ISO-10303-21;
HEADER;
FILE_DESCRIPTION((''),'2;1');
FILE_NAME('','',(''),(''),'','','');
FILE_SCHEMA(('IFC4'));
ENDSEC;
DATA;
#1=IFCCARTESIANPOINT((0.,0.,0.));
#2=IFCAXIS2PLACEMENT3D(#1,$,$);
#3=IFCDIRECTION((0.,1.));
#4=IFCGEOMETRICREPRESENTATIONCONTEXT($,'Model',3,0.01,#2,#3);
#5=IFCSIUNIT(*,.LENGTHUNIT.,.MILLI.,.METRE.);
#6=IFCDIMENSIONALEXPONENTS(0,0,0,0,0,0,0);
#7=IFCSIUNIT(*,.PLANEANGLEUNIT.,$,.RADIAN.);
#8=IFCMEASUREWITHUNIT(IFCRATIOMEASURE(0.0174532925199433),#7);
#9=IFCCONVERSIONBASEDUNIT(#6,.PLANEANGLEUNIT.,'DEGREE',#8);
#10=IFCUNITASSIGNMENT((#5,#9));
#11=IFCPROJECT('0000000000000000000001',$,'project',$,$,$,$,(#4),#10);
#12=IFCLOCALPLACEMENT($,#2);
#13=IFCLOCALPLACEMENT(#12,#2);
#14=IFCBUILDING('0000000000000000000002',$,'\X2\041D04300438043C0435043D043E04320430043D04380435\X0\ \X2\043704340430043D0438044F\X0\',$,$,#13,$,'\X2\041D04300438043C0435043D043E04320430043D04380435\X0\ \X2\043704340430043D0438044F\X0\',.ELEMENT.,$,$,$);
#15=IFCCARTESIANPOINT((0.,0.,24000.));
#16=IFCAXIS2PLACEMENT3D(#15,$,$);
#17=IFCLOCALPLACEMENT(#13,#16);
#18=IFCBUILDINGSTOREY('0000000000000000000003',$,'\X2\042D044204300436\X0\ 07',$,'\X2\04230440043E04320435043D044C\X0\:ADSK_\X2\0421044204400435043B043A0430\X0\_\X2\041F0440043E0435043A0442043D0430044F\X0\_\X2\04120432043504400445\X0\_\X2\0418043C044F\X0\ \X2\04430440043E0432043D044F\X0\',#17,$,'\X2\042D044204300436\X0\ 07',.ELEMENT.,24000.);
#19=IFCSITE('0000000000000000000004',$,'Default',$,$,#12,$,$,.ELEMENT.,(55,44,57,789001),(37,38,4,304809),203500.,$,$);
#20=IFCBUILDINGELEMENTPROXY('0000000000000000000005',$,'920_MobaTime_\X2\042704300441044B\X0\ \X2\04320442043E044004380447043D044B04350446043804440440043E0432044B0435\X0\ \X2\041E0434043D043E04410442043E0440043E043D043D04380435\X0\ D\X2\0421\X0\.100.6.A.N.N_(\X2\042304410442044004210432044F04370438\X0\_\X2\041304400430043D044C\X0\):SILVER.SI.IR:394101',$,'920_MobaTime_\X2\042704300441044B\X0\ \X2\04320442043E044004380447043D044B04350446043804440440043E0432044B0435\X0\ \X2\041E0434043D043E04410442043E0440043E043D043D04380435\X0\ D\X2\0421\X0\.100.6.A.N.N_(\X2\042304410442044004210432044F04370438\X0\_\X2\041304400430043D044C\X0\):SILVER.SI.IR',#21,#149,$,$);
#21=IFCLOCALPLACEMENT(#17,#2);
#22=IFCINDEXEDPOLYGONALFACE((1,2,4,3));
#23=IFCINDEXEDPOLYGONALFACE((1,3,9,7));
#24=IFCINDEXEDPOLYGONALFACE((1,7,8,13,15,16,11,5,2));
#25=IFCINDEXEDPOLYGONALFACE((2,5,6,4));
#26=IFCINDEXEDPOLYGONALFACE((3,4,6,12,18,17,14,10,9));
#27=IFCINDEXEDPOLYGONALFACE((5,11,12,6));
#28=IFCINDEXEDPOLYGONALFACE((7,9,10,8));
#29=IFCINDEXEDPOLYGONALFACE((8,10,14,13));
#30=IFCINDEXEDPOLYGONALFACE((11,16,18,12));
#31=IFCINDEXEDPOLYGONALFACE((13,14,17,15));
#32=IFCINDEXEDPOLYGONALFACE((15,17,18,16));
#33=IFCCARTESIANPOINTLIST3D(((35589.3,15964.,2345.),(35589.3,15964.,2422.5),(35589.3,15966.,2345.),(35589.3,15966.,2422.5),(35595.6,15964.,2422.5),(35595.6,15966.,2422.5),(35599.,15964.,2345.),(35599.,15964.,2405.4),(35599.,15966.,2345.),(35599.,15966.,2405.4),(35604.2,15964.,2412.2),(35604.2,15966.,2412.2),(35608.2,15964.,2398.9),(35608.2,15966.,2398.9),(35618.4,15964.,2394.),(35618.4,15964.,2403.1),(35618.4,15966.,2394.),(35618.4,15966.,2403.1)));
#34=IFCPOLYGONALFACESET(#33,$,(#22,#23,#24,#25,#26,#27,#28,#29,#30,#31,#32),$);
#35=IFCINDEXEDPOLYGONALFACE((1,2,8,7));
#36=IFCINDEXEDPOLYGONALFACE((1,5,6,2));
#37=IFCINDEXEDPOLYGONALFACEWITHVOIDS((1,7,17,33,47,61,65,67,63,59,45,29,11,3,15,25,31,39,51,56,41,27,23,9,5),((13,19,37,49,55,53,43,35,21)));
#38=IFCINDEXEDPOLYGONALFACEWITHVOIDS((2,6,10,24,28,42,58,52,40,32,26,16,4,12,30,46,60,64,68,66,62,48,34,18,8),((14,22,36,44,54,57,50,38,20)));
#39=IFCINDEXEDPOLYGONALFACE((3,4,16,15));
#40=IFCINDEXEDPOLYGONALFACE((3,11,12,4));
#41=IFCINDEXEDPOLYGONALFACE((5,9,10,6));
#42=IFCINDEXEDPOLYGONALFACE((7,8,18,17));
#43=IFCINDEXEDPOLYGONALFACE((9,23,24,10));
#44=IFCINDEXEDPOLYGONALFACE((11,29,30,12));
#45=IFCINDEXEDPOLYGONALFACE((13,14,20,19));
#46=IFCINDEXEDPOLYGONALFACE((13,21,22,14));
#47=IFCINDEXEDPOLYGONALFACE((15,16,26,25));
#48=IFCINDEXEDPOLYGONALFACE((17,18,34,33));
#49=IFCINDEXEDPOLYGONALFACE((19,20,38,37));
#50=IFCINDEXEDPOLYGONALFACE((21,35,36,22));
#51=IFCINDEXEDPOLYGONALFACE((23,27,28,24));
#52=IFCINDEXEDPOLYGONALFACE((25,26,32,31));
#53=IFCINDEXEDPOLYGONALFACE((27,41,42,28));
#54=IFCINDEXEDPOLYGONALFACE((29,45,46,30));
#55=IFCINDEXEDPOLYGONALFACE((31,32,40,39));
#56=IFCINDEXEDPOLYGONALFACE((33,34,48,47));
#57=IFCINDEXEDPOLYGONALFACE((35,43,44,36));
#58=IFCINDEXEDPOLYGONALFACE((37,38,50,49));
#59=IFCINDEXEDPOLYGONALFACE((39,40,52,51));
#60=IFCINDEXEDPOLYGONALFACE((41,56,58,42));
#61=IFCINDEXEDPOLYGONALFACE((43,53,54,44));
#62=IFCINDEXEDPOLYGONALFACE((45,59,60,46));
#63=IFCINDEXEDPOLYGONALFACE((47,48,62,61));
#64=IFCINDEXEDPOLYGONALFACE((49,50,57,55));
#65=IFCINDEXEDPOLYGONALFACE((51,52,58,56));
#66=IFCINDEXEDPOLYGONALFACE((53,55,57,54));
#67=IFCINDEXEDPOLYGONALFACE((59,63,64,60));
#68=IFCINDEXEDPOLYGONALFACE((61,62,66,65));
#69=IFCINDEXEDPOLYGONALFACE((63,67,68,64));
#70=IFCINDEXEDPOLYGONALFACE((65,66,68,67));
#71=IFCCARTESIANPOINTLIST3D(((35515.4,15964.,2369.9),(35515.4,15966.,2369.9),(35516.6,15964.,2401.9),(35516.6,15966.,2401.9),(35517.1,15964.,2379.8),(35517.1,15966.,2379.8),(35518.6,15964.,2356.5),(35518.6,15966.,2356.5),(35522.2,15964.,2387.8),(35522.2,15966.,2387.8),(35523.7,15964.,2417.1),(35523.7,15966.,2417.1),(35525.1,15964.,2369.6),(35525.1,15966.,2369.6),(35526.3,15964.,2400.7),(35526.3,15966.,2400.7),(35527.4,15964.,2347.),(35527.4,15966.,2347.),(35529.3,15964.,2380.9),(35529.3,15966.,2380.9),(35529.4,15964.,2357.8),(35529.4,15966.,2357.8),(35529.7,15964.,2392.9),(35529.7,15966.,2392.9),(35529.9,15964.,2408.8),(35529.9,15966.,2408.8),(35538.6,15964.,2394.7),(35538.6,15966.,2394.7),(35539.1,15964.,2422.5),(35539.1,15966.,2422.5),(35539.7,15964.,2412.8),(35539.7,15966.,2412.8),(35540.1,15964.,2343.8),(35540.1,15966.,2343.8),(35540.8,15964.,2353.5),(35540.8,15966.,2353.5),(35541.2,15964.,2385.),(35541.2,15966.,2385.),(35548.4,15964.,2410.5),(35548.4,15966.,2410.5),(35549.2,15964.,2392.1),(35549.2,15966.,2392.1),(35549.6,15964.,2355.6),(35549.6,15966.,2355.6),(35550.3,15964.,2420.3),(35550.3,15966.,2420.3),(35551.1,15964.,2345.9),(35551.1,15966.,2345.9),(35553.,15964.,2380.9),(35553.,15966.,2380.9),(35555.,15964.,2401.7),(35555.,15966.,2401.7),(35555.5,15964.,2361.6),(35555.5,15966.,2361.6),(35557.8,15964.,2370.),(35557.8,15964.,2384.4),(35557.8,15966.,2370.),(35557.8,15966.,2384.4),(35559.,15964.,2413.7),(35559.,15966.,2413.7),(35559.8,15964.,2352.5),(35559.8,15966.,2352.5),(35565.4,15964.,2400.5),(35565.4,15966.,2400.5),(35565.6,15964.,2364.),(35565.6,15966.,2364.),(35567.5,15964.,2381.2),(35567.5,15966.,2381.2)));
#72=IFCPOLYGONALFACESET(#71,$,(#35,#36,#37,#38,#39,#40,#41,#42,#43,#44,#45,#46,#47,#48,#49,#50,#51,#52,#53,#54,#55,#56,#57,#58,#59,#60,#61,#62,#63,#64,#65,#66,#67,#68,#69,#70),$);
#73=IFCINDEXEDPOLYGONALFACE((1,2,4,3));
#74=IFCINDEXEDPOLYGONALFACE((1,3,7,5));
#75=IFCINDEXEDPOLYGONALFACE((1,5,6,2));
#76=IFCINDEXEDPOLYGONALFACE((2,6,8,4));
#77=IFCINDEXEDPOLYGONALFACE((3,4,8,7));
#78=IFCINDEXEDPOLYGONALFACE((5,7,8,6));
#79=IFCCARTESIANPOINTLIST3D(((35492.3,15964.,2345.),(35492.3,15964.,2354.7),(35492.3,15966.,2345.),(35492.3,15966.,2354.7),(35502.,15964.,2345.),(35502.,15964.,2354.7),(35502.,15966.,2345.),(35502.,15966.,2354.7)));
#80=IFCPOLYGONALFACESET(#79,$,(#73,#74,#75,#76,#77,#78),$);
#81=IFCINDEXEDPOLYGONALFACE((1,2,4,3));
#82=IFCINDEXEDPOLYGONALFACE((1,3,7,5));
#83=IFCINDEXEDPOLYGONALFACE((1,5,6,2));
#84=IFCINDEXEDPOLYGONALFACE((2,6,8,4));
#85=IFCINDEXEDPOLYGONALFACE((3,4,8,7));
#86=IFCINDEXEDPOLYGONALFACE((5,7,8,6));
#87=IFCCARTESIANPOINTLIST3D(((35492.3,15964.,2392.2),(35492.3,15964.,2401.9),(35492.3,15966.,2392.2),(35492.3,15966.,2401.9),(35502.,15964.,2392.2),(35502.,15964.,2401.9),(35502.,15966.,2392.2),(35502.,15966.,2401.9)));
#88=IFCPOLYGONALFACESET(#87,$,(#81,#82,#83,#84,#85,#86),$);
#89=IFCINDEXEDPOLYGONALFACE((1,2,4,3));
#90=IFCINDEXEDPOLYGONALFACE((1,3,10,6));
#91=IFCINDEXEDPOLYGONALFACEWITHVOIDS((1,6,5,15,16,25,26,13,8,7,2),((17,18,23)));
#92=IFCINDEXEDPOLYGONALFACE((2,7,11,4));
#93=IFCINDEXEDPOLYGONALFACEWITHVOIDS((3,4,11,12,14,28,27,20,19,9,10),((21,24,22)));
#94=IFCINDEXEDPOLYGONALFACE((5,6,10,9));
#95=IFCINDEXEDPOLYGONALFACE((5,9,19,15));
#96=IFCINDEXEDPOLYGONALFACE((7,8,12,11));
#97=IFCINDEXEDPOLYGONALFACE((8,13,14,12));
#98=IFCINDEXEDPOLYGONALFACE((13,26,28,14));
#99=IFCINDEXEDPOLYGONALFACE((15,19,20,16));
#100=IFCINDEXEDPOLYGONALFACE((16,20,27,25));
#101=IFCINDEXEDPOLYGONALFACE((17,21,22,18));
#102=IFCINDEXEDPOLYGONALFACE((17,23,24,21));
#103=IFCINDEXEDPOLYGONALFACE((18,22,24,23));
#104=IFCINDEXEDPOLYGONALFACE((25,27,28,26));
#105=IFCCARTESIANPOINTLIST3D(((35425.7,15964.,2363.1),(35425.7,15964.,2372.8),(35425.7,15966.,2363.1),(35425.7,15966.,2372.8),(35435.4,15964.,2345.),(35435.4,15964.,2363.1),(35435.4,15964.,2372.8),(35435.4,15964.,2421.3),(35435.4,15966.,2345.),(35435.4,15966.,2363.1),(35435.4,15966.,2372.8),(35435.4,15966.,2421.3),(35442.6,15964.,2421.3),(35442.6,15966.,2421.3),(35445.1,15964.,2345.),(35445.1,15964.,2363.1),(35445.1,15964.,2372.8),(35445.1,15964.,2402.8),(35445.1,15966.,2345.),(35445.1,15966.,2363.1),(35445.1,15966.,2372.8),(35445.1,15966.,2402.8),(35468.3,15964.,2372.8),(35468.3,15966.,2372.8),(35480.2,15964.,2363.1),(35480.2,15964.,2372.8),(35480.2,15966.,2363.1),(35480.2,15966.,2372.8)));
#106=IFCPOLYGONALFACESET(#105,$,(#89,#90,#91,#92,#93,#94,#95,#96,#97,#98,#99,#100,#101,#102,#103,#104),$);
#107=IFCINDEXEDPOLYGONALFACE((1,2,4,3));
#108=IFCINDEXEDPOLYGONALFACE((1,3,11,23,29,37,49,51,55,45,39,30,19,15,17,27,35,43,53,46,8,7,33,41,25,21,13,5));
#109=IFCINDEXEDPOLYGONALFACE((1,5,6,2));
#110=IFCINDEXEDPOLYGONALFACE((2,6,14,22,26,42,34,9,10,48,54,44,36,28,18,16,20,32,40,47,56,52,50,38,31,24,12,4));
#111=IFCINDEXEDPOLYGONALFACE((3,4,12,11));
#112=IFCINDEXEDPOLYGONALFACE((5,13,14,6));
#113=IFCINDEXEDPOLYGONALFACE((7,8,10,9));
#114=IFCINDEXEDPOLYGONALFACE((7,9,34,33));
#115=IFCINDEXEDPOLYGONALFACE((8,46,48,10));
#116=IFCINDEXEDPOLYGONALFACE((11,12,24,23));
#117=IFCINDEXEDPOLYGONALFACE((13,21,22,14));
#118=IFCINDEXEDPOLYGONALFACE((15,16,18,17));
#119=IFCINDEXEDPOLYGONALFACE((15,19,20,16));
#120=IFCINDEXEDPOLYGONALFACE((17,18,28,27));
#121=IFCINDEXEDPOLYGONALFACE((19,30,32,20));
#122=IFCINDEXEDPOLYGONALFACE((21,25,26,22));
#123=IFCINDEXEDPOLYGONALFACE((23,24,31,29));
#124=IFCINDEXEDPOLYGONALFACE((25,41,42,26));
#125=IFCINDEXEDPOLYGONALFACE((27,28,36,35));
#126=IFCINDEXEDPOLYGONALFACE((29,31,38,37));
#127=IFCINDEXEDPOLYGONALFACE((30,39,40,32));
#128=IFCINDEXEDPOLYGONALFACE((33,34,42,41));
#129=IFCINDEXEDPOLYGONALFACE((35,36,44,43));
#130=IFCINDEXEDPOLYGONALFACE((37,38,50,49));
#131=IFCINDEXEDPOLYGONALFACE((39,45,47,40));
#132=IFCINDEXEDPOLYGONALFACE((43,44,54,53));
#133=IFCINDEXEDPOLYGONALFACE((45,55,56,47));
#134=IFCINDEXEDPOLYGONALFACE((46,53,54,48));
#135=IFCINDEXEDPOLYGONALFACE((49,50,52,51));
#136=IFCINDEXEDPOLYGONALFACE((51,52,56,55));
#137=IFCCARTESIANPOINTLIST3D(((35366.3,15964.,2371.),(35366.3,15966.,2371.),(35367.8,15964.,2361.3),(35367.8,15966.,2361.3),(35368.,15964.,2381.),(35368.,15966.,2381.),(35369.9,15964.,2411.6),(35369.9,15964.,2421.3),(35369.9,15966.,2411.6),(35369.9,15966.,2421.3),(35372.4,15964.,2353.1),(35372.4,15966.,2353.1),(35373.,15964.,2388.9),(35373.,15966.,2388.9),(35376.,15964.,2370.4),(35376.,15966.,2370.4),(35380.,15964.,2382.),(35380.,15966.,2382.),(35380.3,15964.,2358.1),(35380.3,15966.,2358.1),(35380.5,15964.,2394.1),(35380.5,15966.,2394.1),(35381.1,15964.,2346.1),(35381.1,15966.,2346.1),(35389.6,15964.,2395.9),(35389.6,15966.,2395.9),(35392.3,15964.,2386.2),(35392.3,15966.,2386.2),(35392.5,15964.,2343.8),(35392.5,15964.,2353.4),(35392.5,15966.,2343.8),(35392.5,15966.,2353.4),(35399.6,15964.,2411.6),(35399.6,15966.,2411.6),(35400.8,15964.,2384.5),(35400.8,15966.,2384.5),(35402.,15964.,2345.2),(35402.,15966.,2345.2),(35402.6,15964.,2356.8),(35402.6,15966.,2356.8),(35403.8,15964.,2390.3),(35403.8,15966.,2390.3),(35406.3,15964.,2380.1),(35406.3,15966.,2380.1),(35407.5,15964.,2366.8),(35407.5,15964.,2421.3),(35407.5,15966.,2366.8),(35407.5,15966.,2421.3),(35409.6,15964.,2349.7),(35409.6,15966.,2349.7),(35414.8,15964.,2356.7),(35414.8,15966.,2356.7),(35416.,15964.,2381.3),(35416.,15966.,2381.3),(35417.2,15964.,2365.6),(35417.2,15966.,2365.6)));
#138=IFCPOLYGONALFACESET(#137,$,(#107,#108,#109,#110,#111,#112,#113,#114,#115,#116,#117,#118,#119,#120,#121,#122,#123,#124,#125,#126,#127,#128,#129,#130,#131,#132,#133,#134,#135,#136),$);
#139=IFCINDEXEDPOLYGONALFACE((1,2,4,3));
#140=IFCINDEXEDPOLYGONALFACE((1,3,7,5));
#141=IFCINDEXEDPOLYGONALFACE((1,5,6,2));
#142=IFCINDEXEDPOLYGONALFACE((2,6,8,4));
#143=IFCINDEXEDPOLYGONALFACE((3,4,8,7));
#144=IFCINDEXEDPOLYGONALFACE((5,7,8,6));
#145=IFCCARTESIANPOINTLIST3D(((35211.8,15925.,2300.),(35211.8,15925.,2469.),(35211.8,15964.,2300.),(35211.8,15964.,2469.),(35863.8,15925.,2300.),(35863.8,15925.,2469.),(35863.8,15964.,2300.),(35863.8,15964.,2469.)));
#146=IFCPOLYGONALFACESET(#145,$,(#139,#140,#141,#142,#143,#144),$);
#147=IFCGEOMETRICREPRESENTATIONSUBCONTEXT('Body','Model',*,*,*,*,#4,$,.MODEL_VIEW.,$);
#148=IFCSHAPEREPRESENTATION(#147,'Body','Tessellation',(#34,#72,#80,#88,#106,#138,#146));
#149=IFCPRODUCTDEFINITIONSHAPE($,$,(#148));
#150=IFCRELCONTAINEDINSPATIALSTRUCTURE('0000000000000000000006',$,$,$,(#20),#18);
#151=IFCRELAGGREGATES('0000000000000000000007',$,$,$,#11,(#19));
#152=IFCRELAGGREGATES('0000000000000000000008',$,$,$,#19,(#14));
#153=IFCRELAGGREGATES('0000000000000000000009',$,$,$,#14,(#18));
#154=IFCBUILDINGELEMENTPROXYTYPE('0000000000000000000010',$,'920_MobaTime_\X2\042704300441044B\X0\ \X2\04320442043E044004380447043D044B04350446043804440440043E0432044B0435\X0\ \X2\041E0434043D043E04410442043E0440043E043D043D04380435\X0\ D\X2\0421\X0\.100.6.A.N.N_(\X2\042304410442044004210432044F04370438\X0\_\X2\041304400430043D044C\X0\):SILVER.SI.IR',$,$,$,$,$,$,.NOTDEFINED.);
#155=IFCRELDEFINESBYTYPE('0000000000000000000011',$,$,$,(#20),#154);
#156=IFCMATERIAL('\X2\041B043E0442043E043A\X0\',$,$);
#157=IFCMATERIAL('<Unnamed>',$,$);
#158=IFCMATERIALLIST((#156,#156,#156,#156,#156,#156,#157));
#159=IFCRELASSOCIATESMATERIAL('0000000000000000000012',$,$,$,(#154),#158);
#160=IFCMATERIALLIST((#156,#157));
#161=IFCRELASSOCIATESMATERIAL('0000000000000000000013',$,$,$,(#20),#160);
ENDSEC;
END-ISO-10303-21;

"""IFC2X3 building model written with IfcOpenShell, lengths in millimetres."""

from ifc_helpers import new_model, entity, si_unit, converted_unit, direction, frame, origin, origin_2d_with_axis, place, context, subcontext, project, spatial, polyline, rectangle, outline, extrude, source, transform, mapped, material, material_list, type_object, type_shapes, element, save


model = new_model("IFC2X3")

# Units and contexts
model_context = context("Model", 3, precision=0.01, world=origin(), true_north=direction((0.0, 1.0)))
body_context = subcontext(model_context, "Body", "Model", "MODEL_VIEW")
ifc_project = project(units=[si_unit("LENGTHUNIT", "METRE", prefix="MILLI"), converted_unit("PLANEANGLEUNIT", "DEGREE", entity("IfcRatioMeasure", 0.0174532925199433), si_unit("PLANEANGLEUNIT", "RADIAN"), dimensions=[0, 0, 0, 0, 0, 0, 0])], contexts=[model_context])

# Site, building, storey
site_placement = place(None, origin())
site = spatial("IfcSite", under=ifc_project, at=site_placement, Name="Default", CompositionType="ELEMENT", RefLatitude=(55, 44, 57, 789001), RefLongitude=(37, 38, 4, 304809), RefElevation=203500.0)
building_placement = place(site_placement, origin())
building = spatial("IfcBuilding", under=site, at=building_placement, Name="Наименование здания", LongName="Наименование здания", CompositionType="ELEMENT")
storey_placement = place(building_placement, frame((0.0, 0.0, 24000.0)))
storey = spatial("IfcBuildingStorey", under=building, at=storey_placement, Name="Этаж 07", ObjectType="Уровень:ADSK_Стрелка_Проектная_Вверх_Имя уровня", LongName="Этаж 07", CompositionType="ELEMENT", Elevation=24000.0)

# Building element proxy
ifc_material_1 = material(Name="Лоток")
ifc_material_2 = material(Name="<Unnamed>")
ifc_material_list_1 = material_list([ifc_material_1, ifc_material_2])
ifc_material_list_2 = material_list([ifc_material_1, ifc_material_1, ifc_material_1, ifc_material_1, ifc_material_1, ifc_material_1, ifc_material_2])
building_element_proxy_type = type_object("IfcBuildingElementProxyType", Name="920_MobaTime_Часы вторичныецифровые Односторонние DС.100.6.A.N.N_(УстрСвязи_Грань):SILVER.SI.IR", PredefinedType="NOTDEFINED", material=ifc_material_list_2)
shared_shape = source(origin(), body_context, "Body", "SweptSolid", [
    extrude(outline(polyline([(-49.3, -13.1), (28.2, -13.1), (28.2, -6.8), (17.9, 1.8), (8.8, 16.0), (-0.3, 16.0), (4.6, 5.8), (11.1, -3.4), (-49.3, -3.4), (-49.3, -13.1)])), frame((-64.6, 9.8, 39.0), z_axis=(0.0, 0.0, 1.0), x_axis=(0.0, 1.0, 0.0)), (0.0, 0.0, 1.0), 2.0),
    extrude(outline(polyline([(2.2, -27.6), (19.0, -27.6), (30.5, -16.1), (33.3, -4.9), (31.0, 5.8), (21.8, 17.2), (5.2, 27.3), (-11.1, 33.0), (-24.0, 32.7), (-33.6, 27.6), (-40.3, 18.6), (-42.8, 5.7), (-38.0, -6.3), (-27.2, -14.9), (-17.5, -17.7), (-8.2, -16.4), (-0.3, -11.9), (5.1, -4.5), (7.3, 6.2), (4.0, 17.2), (18.4, 7.3), (23.6, -2.4), (22.0, -11.4), (14.2, -18.4), (5.3, -18.3), (2.2, -27.6)]), holes=[polyline([(-9.0, 23.3), (-1.3, 14.3), (-2.5, 2.0), (-11.4, -7.0), (-23.4, -6.0), (-32.2, 2.9), (-31.2, 15.1), (-25.6, 22.1), (-17.5, 24.9), (-9.0, 23.3)])]), frame((-2.7, 3.6, 39.0), z_axis=(0.0, 0.0, 1.0), x_axis=(-0.427649, 0.903945, 0.0)), (0.0, 0.0, 1.0), 2.0),
    extrude(rectangle(XDim=9.7, YDim=9.7, at=origin_2d_with_axis()), frame((40.6, -34.7, 39.0)), (0.0, 0.0, 1.0), 2.0),
    extrude(rectangle(XDim=9.7, YDim=9.7, at=origin_2d_with_axis()), frame((40.6, 12.6, 39.0)), (0.0, 0.0, 1.0), 2.0),
    extrude(outline(polyline([(-0.9, -28.1), (8.8, -28.1), (8.8, -9.9), (18.5, -9.9), (18.5, -0.2), (8.8, -0.2), (8.8, 48.3), (1.5, 48.3), (-36.0, -0.2), (-36.0, -9.9), (-0.9, -9.9), (-0.9, -28.1)]), holes=[polyline([(-0.9, -0.2), (-24.1, -0.2), (-0.9, 29.7), (-0.9, -0.2)])]), frame((93.6, -11.4, 39.0)), (0.0, 0.0, 1.0), 2.0),
    extrude(outline(polyline([(3.3, -28.3), (12.5, -28.3), (20.5, -25.0), (26.8, -18.9), (30.7, -10.0), (31.4, 1.6), (26.9, 11.8), (20.1, 18.4), (11.1, 22.3), (1.0, 23.3), (-7.9, 20.4), (-14.9, 14.5), (-18.9, 6.2), (-17.1, -9.0), (-36.7, 0.5), (-29.1, 29.2), (-38.5, 31.7), (-48.1, -4.6), (-11.6, -23.1), (-8.0, -14.0), (-10.8, -7.6), (-10.2, 1.1), (-3.0, 11.8), (9.2, 12.8), (20.0, 5.5), (21.4, -7.5), (15.5, -16.4), (4.6, -18.6), (3.3, -28.3)])), frame((147.1, -8.5, 39.0), z_axis=(0.0, 0.0, 1.0), x_axis=(0.256974, -0.966418, 0.0)), (0.0, 0.0, 1.0), 2.0),
    extrude(rectangle(XDim=652.0, YDim=169.0, at=origin_2d_with_axis()), frame((0.0, 0.0, 0.0), z_axis=(0.0, 0.0, 1.0), x_axis=(-1.0, 0.0, 0.0)), (0.0, 0.0, 1.0), 39.0),
])
type_shapes(building_element_proxy_type, [shared_shape])
for number, where, z_axis, x_axis, name in (
    (1, (35537.8, 15925.0, 2384.5), (0.0, 1.0, 0.0), (-1.0, 0.0, 0.0), "920_MobaTime_Часы вторичныецифровые Односторонние DС.100.6.A.N.N_(УстрСвязи_Грань):SILVER.SI.IR:394101"),
):
    element("IfcBuildingElementProxy", number, at=place(storey_placement, frame(where, z_axis=z_axis, x_axis=x_axis)), inside=storey, type_object=building_element_proxy_type, material=ifc_material_list_1, Name=name, ObjectType="920_MobaTime_Часы вторичныецифровые Односторонние DС.100.6.A.N.N_(УстрСвязи_Грань):SILVER.SI.IR", context=body_context, shape_type="MappedRepresentation", body=[
        mapped(shared_shape, transform((0.0, 0.0, 0.0), scale=1.0)),
    ])

save(model, "model.ifc")
